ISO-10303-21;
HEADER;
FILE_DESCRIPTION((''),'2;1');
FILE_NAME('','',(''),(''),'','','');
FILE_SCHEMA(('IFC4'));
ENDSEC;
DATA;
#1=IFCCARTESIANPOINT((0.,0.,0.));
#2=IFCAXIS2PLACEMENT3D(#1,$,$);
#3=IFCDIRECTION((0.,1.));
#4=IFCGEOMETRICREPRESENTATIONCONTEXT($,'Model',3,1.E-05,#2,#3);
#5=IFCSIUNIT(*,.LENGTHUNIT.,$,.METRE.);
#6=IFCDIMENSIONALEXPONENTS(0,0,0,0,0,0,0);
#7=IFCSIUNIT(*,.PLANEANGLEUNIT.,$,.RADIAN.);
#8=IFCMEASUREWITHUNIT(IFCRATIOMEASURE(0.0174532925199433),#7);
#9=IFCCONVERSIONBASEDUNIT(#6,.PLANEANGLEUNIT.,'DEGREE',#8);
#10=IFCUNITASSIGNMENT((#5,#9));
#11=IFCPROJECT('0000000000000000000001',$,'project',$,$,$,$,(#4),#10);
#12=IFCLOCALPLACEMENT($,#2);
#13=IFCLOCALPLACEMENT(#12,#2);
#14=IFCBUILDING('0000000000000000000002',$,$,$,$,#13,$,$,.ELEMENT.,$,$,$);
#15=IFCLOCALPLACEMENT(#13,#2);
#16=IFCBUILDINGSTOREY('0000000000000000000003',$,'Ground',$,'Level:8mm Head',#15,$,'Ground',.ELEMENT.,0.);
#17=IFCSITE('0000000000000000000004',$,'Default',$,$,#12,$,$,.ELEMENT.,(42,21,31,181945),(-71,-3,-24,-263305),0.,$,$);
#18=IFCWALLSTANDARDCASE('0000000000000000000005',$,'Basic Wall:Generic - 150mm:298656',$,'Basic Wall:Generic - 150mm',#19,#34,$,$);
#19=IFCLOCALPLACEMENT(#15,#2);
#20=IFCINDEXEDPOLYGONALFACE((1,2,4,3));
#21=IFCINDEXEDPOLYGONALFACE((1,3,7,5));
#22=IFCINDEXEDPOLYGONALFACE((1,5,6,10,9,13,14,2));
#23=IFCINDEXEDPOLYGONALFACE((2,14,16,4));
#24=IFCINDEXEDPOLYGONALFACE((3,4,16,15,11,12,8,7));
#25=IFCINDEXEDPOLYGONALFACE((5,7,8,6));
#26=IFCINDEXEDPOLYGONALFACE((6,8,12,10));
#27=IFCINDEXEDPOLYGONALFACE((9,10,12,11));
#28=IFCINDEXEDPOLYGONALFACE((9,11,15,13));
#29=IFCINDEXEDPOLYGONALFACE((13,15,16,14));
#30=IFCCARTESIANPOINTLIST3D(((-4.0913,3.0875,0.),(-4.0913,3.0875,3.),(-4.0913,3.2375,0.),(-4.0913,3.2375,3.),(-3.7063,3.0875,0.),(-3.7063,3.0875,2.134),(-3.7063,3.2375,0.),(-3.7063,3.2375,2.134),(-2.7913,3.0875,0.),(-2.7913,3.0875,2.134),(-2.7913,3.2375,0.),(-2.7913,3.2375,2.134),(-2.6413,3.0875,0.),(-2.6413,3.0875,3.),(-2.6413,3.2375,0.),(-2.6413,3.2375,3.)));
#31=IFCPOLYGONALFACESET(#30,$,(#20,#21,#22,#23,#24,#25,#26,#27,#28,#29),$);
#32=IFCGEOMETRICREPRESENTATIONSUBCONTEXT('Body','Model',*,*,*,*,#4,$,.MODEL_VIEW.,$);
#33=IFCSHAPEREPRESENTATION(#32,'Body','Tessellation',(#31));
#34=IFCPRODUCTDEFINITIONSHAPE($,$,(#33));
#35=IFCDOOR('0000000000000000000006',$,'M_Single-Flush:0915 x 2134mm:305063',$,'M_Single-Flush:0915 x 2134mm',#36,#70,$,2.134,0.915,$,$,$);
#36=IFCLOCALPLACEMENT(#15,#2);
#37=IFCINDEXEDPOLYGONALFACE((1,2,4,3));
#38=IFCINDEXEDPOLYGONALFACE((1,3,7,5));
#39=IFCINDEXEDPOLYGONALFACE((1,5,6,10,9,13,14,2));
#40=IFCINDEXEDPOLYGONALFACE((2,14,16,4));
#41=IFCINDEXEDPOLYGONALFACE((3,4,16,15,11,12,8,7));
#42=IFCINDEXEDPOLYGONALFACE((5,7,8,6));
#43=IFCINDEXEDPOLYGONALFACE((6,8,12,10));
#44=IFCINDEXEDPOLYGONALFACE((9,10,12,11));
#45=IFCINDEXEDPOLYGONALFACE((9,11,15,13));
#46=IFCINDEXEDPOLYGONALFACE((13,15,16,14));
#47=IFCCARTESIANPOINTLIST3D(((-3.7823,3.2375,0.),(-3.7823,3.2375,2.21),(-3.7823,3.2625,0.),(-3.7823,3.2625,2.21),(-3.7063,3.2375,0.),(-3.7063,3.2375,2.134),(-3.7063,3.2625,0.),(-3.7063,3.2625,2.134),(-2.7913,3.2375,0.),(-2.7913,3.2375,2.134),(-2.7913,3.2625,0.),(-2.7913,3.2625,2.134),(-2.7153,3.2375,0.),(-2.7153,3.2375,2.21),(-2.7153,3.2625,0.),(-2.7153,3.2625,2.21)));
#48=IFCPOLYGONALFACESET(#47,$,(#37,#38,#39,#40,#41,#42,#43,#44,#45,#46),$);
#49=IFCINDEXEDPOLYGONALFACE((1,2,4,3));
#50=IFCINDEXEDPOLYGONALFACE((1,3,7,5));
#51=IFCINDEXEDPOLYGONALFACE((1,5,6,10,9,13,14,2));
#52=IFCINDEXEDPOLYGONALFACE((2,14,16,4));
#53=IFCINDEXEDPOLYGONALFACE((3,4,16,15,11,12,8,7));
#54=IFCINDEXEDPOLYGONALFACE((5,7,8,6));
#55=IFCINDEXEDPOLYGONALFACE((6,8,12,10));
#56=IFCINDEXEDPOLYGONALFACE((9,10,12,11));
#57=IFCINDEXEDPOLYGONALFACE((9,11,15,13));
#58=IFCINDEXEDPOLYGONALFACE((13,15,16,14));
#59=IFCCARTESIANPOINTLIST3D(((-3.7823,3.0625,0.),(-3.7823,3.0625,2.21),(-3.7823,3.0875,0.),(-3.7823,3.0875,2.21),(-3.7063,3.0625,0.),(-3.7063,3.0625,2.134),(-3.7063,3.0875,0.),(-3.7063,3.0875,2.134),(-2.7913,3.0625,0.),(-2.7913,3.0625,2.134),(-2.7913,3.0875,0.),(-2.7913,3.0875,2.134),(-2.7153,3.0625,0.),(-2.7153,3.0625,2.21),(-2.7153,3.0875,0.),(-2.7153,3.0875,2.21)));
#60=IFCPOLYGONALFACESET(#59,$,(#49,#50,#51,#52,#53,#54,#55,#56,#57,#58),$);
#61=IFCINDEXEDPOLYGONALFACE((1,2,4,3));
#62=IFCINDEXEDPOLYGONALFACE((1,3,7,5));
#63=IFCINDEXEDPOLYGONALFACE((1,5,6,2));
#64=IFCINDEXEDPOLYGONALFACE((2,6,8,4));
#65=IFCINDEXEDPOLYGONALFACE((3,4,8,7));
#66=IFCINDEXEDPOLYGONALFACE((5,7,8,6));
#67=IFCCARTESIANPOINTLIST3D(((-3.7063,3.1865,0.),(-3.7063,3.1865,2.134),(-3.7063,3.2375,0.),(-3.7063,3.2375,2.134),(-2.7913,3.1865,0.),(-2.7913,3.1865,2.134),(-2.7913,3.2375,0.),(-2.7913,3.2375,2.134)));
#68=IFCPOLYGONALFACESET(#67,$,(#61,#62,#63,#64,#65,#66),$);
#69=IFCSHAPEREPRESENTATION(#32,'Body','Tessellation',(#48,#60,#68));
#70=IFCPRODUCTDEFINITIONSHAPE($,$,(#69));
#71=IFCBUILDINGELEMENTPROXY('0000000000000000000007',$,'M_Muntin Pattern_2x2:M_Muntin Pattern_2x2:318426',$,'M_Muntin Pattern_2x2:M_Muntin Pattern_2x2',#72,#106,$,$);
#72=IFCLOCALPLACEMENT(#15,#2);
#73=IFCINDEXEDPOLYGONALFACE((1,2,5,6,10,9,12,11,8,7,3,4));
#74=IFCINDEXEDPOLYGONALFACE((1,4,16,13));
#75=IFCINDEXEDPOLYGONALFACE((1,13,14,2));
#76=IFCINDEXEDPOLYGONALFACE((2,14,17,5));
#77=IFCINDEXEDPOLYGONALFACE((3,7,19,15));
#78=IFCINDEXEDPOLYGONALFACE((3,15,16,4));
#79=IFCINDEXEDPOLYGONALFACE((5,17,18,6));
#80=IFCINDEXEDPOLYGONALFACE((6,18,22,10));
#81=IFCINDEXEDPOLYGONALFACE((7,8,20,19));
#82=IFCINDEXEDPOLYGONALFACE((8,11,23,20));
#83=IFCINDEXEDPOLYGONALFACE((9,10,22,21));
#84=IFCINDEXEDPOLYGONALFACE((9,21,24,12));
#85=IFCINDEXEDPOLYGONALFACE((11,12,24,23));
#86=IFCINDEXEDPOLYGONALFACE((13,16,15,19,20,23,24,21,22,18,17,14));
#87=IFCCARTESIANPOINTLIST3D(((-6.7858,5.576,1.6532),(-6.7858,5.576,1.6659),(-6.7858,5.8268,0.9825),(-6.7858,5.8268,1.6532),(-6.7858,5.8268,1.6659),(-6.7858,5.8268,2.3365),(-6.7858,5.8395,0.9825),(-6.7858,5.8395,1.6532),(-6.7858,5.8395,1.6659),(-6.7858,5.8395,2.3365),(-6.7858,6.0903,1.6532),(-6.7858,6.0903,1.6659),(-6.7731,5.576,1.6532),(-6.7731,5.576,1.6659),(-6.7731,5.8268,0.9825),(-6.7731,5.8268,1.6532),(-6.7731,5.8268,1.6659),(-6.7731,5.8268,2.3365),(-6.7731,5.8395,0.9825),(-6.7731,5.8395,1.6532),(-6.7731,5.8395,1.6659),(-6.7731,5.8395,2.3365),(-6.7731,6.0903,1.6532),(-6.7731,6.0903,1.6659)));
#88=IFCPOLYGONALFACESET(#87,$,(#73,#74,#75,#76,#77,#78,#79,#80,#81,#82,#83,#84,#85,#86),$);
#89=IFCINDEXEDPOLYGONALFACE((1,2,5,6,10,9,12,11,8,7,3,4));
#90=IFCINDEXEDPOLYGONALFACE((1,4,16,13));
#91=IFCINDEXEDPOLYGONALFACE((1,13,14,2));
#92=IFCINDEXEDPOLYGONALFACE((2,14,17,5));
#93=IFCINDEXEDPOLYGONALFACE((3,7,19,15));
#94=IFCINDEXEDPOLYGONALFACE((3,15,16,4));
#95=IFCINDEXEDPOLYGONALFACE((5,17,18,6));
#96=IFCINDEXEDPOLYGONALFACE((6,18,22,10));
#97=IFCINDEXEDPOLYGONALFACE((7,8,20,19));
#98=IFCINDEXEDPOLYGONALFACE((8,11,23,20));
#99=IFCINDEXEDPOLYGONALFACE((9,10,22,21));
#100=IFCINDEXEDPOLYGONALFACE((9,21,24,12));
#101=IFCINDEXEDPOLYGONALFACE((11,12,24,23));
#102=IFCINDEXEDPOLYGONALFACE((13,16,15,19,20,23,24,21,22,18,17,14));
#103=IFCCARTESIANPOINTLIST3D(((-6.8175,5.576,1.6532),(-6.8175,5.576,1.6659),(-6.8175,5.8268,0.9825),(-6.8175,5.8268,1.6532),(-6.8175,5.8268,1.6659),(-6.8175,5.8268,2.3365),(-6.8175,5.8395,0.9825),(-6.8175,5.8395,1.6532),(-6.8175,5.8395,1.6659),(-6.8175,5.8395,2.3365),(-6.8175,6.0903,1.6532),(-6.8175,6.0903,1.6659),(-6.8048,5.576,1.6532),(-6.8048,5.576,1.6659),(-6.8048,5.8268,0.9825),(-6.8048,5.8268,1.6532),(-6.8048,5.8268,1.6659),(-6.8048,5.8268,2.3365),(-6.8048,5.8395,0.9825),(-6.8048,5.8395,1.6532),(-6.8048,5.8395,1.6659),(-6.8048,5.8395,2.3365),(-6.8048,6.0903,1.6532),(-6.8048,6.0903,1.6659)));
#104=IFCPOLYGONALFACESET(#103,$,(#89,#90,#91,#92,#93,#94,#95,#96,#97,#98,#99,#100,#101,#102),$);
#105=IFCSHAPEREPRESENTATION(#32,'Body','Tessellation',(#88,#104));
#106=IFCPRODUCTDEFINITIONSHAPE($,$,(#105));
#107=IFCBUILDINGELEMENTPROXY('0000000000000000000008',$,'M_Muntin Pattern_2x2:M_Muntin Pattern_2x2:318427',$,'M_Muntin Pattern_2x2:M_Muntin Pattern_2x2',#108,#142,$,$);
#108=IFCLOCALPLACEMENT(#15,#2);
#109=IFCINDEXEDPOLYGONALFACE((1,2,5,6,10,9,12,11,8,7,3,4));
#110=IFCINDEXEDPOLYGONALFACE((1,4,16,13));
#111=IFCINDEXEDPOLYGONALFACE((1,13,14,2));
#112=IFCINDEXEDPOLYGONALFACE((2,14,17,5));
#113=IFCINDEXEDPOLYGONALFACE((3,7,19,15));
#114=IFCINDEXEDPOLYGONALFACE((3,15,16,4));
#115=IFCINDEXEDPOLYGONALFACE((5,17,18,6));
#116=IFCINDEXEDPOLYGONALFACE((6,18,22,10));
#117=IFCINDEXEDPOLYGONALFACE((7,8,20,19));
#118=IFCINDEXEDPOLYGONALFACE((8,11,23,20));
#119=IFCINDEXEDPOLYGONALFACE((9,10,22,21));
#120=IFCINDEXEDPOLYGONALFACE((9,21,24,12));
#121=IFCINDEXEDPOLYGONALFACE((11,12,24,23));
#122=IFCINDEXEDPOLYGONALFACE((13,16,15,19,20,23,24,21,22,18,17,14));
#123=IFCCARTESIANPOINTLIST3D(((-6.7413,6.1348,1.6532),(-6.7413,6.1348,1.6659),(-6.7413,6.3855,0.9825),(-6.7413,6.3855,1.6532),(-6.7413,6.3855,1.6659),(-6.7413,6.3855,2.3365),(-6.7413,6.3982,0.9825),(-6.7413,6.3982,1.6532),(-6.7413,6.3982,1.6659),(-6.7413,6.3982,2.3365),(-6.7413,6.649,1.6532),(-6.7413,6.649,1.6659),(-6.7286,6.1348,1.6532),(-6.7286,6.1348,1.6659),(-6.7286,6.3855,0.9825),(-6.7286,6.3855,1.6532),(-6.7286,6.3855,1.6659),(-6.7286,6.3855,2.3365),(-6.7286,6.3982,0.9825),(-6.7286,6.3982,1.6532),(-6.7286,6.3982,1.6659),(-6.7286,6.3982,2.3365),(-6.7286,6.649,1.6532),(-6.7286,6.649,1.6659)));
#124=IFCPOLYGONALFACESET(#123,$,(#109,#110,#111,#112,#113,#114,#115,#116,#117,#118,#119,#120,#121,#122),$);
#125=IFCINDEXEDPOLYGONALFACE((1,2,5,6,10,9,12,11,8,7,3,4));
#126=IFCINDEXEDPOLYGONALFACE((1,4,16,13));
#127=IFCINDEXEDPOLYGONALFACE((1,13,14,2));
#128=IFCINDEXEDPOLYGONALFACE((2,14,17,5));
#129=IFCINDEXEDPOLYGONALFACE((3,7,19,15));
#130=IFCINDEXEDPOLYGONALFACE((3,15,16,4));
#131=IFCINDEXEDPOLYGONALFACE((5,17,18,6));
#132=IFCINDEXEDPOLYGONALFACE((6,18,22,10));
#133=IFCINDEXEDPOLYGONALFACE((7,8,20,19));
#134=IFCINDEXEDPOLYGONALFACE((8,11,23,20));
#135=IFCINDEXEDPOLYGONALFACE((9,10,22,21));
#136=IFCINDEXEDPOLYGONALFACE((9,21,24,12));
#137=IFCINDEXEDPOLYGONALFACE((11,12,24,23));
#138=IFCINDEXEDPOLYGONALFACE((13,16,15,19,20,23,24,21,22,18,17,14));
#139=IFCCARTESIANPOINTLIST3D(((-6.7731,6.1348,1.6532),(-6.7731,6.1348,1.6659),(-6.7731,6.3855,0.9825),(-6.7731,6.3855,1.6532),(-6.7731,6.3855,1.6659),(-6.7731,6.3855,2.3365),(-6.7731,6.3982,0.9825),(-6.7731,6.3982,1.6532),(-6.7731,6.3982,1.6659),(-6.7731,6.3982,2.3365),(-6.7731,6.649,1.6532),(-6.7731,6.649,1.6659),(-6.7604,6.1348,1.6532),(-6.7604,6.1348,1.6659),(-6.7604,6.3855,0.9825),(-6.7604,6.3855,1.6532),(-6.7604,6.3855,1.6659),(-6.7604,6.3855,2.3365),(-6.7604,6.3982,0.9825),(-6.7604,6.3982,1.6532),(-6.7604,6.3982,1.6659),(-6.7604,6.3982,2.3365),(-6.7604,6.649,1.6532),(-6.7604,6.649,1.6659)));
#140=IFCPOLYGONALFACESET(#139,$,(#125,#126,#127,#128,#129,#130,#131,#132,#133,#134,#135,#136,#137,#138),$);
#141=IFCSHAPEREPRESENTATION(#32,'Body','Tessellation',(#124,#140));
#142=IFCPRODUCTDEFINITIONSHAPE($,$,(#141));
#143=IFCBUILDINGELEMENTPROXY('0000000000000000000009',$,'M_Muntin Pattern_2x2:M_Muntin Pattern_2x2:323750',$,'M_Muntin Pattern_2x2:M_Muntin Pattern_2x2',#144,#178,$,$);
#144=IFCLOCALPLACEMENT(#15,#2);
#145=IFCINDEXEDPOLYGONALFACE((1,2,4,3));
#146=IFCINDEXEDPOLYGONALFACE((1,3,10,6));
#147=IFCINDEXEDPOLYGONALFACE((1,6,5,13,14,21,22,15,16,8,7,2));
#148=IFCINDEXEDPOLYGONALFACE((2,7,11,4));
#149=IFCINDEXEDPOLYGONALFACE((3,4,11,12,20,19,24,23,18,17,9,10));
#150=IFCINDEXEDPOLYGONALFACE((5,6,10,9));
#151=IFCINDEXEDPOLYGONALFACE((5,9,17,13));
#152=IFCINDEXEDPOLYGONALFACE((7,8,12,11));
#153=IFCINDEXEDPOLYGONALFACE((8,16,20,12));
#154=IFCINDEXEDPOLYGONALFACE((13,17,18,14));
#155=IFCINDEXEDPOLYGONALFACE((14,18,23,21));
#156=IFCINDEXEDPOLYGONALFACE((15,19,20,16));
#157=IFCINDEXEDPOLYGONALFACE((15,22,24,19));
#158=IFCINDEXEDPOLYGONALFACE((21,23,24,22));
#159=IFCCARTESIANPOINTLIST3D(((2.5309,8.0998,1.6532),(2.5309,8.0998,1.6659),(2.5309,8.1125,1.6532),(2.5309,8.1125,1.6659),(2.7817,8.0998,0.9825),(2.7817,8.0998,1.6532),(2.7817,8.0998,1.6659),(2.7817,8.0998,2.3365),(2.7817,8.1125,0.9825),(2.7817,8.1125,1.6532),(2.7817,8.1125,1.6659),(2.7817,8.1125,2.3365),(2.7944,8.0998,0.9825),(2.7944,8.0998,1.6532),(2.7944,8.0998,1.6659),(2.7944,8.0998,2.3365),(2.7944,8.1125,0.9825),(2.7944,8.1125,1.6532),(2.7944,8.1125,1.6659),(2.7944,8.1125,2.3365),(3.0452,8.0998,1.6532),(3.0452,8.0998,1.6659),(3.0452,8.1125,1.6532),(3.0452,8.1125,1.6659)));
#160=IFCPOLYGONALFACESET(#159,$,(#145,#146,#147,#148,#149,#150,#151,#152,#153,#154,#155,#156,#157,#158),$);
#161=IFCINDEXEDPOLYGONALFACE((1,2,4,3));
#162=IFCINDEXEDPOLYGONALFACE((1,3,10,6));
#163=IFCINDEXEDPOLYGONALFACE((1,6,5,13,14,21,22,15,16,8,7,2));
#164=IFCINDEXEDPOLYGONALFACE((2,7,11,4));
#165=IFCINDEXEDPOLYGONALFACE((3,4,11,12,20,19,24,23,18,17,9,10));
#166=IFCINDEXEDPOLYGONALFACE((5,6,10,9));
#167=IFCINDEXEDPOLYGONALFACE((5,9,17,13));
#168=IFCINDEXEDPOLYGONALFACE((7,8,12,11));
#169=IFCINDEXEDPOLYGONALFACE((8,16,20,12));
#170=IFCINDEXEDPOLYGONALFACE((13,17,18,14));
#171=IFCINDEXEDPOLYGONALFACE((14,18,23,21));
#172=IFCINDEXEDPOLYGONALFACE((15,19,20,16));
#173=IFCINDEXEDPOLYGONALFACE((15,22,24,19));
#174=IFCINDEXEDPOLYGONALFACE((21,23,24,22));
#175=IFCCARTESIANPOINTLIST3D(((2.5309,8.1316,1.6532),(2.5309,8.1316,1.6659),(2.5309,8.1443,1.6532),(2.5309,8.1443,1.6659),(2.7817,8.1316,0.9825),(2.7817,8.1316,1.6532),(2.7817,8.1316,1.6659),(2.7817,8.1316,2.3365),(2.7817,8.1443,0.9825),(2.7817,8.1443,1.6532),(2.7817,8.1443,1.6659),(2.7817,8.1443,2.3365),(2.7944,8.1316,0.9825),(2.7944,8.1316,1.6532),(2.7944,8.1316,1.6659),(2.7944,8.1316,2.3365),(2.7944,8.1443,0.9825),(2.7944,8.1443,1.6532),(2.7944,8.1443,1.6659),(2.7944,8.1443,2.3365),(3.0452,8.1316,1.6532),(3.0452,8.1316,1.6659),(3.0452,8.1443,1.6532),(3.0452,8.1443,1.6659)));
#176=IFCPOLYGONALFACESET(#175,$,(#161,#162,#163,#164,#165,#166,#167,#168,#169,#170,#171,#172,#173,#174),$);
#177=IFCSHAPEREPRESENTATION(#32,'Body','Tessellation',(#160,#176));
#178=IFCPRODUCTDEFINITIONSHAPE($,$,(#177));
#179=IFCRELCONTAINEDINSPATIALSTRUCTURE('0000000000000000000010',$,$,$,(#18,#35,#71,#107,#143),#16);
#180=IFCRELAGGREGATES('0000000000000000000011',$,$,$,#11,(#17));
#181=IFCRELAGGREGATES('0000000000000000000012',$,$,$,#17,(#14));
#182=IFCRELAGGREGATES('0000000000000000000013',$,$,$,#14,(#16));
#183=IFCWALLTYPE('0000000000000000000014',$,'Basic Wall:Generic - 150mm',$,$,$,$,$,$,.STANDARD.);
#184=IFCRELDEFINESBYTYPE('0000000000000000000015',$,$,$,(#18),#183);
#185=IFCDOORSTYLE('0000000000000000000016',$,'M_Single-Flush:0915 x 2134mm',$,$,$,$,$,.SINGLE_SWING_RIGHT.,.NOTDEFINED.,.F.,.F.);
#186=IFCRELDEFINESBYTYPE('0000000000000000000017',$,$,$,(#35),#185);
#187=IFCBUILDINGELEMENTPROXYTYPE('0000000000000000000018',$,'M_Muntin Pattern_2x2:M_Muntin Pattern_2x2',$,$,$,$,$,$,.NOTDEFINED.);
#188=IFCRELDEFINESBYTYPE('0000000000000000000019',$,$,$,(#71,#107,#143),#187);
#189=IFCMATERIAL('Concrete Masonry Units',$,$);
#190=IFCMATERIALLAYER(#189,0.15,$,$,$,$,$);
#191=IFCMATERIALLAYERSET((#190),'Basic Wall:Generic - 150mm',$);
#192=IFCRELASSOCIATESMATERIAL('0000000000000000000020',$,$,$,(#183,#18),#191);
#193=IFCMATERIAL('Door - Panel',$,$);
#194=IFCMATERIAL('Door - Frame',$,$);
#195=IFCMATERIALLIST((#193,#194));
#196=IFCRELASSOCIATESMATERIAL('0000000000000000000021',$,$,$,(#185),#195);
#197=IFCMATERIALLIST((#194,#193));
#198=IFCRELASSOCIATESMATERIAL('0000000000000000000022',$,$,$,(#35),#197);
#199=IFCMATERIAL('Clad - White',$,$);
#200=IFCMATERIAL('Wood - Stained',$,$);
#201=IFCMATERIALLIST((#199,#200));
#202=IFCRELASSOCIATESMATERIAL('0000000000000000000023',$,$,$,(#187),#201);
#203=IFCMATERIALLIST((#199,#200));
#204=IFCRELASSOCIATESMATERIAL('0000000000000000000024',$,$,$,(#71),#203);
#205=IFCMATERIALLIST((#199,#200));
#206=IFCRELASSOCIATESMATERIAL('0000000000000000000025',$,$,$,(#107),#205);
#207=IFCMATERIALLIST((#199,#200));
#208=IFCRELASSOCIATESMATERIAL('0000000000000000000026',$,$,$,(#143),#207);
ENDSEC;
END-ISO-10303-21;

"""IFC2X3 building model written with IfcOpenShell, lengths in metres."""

from ifc_helpers import new_model, entity, si_unit, converted_unit, direction, frame, frame_2d, origin, place, context, subcontext, project, spatial, polyline, rectangle, outline, extrude, source, transform, mapped, material, material_list, layer, layer_set, layer_usage, type_object, type_shapes, element, fill, save


model = new_model("IFC2X3")

# Units and contexts
model_context = context("Model", 3, precision=1e-05, world=origin(), true_north=direction((0.0, 1.0)))
body_context = subcontext(model_context, "Body", "Model", "MODEL_VIEW")
ifc_project = project(units=[si_unit("LENGTHUNIT", "METRE"), converted_unit("PLANEANGLEUNIT", "DEGREE", entity("IfcRatioMeasure", 0.0174532925199433), si_unit("PLANEANGLEUNIT", "RADIAN"), dimensions=[0, 0, 0, 0, 0, 0, 0])], contexts=[model_context])

# Site, building, storey
site_placement = place(None, origin())
site = spatial("IfcSite", under=ifc_project, at=site_placement, Name="Default", CompositionType="ELEMENT", RefLatitude=(42, 21, 31, 181945), RefLongitude=(-71, -3, -24, -263305), RefElevation=0.0)
building_placement = place(site_placement, origin())
building = spatial("IfcBuilding", under=site, at=building_placement, CompositionType="ELEMENT")
storey_placement = place(building_placement, origin())
storey = spatial("IfcBuildingStorey", under=building, at=storey_placement, Name="Ground", ObjectType="Level:8mm Head", LongName="Ground", CompositionType="ELEMENT", Elevation=0.0)

# Shared definitions
ifc_material_1 = material(Name="Concrete Masonry Units")
ifc_layer = layer(ifc_material_1, 0.15)
ifc_layer_set = layer_set([ifc_layer], Name="Basic Wall:Generic - 150mm")
wall_type = type_object("IfcWallType", Name="Basic Wall:Generic - 150mm", PredefinedType="STANDARD", material=ifc_layer_set)

# Shared definitions
ifc_material_2 = material(Name="Door - Frame")
ifc_material_3 = material(Name="Door - Panel")

# Wall, opening, door
ifc_layer_usage_1 = layer_usage(ifc_layer_set, "AXIS2", "NEGATIVE", 0.075)
wall_1_placement = place(storey_placement, frame((-4.0913, 3.1625, 0.0)))
wall_1 = element("IfcWallStandardCase", 1, at=wall_1_placement, inside=storey, type_object=wall_type, material=ifc_layer_usage_1, Name="Basic Wall:Generic - 150mm:298656", ObjectType="Basic Wall:Generic - 150mm", context=body_context, shape_type="SweptSolid", body=[
    extrude(rectangle(XDim=1.45, YDim=0.15, at=frame_2d((0.725, 0.0), x_axis=(-1.0, 0.0))), origin(), (0.0, 0.0, 1.0), 3.0),
])
opening_1_placement = place(wall_1_placement, frame((0.385, -0.075, 0.0)))
opening_1 = element("IfcOpeningElement", 2, at=opening_1_placement, cuts=wall_1, ObjectType="Opening", context=body_context, shape_type="SweptSolid", body=[
    extrude(rectangle(XDim=0.915, YDim=2.134, at=frame_2d((1.067, 0.4575), x_axis=(0.0, 1.0))), frame((0.0, 0.0, 0.0), z_axis=(0.0, 1.0, 0.0), x_axis=(0.0, 0.0, 1.0)), (0.0, 0.0, 1.0), 0.15),
])
ifc_material_list_1 = material_list([ifc_material_2, ifc_material_3])
ifc_material_list_2 = material_list([ifc_material_3, ifc_material_2])
door_style_1 = type_object("IfcDoorStyle", Name="M_Single-Flush:0915 x 2134mm", ConstructionType="NOTDEFINED", OperationType="SINGLE_SWING_RIGHT", ParameterTakesPrecedence=False, Sizeable=False, material=ifc_material_list_2)
shared_shape_1 = source(origin(), body_context, "Body", "SweptSolid", [
    extrude(outline(polyline([(-0.5335, -1.124), (0.5335, -1.124), (0.5335, 1.086), (0.4575, 1.086), (0.4575, -1.048), (-0.4575, -1.048), (-0.4575, 1.086), (-0.5335, 1.086), (-0.5335, -1.124)])), frame((0.4575, 0.15, 1.086), z_axis=(0.0, 1.0, 0.0), x_axis=(1.0, 0.0, 0.0)), (0.0, 0.0, 1.0), 0.025),
    extrude(outline(polyline([(-1.124, -0.5335), (1.086, -0.5335), (1.086, -0.4575), (-1.048, -0.4575), (-1.048, 0.4575), (1.086, 0.4575), (1.086, 0.5335), (-1.124, 0.5335), (-1.124, -0.5335)])), frame((0.4575, -0.025, 1.086), z_axis=(0.0, 1.0, 0.0), x_axis=(0.0, 0.0, -1.0)), (0.0, 0.0, 1.0), 0.025),
    extrude(rectangle(XDim=0.051, YDim=0.915, at=frame_2d((0.0, 0.0), x_axis=(1.0, 0.0))), frame((0.4575, 0.1245, 0.0), z_axis=(0.0, 0.0, 1.0), x_axis=(0.0, 1.0, 0.0)), (0.0, 0.0, 1.0), 2.134),
])
type_shapes(door_style_1, [shared_shape_1])
door_1_placement = place(opening_1_placement, origin())
door_1 = element("IfcDoor", 3, at=door_1_placement, inside=storey, type_object=door_style_1, material=ifc_material_list_1, Name="M_Single-Flush:0915 x 2134mm:305063", ObjectType="M_Single-Flush:0915 x 2134mm", OverallHeight=2.134, OverallWidth=0.915, context=body_context, shape_type="MappedRepresentation", body=[
    mapped(shared_shape_1, transform((0.0, 0.0, 0.0), scale=1.0)),
])
fill(opening_1, door_1)

# Building element proxies
ifc_material_4 = material(Name="Clad - White")
ifc_material_5 = material(Name="Wood - Stained")
ifc_material_list_3 = material_list([ifc_material_4, ifc_material_5])
ifc_material_list_4 = material_list([ifc_material_4, ifc_material_5])
building_element_proxy_type_1 = type_object("IfcBuildingElementProxyType", Name="M_Muntin Pattern_2x2:M_Muntin Pattern_2x2", PredefinedType="NOTDEFINED", material=ifc_material_list_4)
shared_shape_2 = source(origin(), body_context, "Body", "SweptSolid", [
    extrude(outline(polyline([(0.0064, -0.0064), (0.677, -0.0064), (0.677, 0.0063), (0.0064, 0.0063), (0.0064, 0.2571), (-0.0063, 0.2571), (-0.0063, 0.0063), (-0.677, 0.0063), (-0.677, -0.0064), (-0.0063, -0.0064), (-0.0063, -0.2571), (0.0064, -0.2571), (0.0064, -0.0064)])), frame((0.0, 0.0095, 0.677), z_axis=(0.0, 1.0, 0.0), x_axis=(0.0, 0.0, 1.0)), (0.0, 0.0, 1.0), 0.0127),
    extrude(outline(polyline([(0.0064, -0.0064), (0.677, -0.0064), (0.677, 0.0063), (0.0064, 0.0063), (0.0064, 0.2571), (-0.0063, 0.2571), (-0.0063, 0.0063), (-0.677, 0.0063), (-0.677, -0.0064), (-0.0063, -0.0064), (-0.0063, -0.2571), (0.0064, -0.2571), (0.0064, -0.0064)])), frame((0.0, -0.0222, 0.677), z_axis=(0.0, 1.0, 0.0), x_axis=(0.0, 0.0, 1.0)), (0.0, 0.0, 1.0), 0.0127),
])
type_shapes(building_element_proxy_type_1, [shared_shape_2])
proxy_1_placement = place(storey_placement, frame((-6.7953, 5.8332, 0.9825), z_axis=(0.0, 0.0, 1.0), x_axis=(0.0, -1.0, 0.0)))
element("IfcBuildingElementProxy", 4, at=proxy_1_placement, inside=storey, type_object=building_element_proxy_type_1, material=ifc_material_list_3, Name="M_Muntin Pattern_2x2:M_Muntin Pattern_2x2:318426", ObjectType="M_Muntin Pattern_2x2:M_Muntin Pattern_2x2", context=body_context, shape_type="MappedRepresentation", body=[
    mapped(shared_shape_2, transform((0.0, 0.0, 0.0), scale=1.0)),
])
ifc_material_list_5 = material_list([ifc_material_4, ifc_material_5])
proxy_2_placement = place(storey_placement, frame((-6.7509, 6.3919, 0.9825), z_axis=(0.0, 0.0, 1.0), x_axis=(0.0, -1.0, 0.0)))
element("IfcBuildingElementProxy", 5, at=proxy_2_placement, inside=storey, type_object=building_element_proxy_type_1, material=ifc_material_list_5, Name="M_Muntin Pattern_2x2:M_Muntin Pattern_2x2:318427", ObjectType="M_Muntin Pattern_2x2:M_Muntin Pattern_2x2", context=body_context, shape_type="MappedRepresentation", body=[
    mapped(shared_shape_2, transform((0.0, 0.0, 0.0), scale=1.0)),
])
ifc_material_list_6 = material_list([ifc_material_4, ifc_material_5])
proxy_3_placement = place(storey_placement, frame((2.788, 8.1221, 0.9825), z_axis=(0.0, 0.0, 1.0), x_axis=(-1.0, 0.0, 0.0)))
element("IfcBuildingElementProxy", 6, at=proxy_3_placement, inside=storey, type_object=building_element_proxy_type_1, material=ifc_material_list_6, Name="M_Muntin Pattern_2x2:M_Muntin Pattern_2x2:323750", ObjectType="M_Muntin Pattern_2x2:M_Muntin Pattern_2x2", context=body_context, shape_type="MappedRepresentation", body=[
    mapped(shared_shape_2, transform((0.0, 0.0, 0.0), scale=1.0)),
])

save(model, "model.ifc")
